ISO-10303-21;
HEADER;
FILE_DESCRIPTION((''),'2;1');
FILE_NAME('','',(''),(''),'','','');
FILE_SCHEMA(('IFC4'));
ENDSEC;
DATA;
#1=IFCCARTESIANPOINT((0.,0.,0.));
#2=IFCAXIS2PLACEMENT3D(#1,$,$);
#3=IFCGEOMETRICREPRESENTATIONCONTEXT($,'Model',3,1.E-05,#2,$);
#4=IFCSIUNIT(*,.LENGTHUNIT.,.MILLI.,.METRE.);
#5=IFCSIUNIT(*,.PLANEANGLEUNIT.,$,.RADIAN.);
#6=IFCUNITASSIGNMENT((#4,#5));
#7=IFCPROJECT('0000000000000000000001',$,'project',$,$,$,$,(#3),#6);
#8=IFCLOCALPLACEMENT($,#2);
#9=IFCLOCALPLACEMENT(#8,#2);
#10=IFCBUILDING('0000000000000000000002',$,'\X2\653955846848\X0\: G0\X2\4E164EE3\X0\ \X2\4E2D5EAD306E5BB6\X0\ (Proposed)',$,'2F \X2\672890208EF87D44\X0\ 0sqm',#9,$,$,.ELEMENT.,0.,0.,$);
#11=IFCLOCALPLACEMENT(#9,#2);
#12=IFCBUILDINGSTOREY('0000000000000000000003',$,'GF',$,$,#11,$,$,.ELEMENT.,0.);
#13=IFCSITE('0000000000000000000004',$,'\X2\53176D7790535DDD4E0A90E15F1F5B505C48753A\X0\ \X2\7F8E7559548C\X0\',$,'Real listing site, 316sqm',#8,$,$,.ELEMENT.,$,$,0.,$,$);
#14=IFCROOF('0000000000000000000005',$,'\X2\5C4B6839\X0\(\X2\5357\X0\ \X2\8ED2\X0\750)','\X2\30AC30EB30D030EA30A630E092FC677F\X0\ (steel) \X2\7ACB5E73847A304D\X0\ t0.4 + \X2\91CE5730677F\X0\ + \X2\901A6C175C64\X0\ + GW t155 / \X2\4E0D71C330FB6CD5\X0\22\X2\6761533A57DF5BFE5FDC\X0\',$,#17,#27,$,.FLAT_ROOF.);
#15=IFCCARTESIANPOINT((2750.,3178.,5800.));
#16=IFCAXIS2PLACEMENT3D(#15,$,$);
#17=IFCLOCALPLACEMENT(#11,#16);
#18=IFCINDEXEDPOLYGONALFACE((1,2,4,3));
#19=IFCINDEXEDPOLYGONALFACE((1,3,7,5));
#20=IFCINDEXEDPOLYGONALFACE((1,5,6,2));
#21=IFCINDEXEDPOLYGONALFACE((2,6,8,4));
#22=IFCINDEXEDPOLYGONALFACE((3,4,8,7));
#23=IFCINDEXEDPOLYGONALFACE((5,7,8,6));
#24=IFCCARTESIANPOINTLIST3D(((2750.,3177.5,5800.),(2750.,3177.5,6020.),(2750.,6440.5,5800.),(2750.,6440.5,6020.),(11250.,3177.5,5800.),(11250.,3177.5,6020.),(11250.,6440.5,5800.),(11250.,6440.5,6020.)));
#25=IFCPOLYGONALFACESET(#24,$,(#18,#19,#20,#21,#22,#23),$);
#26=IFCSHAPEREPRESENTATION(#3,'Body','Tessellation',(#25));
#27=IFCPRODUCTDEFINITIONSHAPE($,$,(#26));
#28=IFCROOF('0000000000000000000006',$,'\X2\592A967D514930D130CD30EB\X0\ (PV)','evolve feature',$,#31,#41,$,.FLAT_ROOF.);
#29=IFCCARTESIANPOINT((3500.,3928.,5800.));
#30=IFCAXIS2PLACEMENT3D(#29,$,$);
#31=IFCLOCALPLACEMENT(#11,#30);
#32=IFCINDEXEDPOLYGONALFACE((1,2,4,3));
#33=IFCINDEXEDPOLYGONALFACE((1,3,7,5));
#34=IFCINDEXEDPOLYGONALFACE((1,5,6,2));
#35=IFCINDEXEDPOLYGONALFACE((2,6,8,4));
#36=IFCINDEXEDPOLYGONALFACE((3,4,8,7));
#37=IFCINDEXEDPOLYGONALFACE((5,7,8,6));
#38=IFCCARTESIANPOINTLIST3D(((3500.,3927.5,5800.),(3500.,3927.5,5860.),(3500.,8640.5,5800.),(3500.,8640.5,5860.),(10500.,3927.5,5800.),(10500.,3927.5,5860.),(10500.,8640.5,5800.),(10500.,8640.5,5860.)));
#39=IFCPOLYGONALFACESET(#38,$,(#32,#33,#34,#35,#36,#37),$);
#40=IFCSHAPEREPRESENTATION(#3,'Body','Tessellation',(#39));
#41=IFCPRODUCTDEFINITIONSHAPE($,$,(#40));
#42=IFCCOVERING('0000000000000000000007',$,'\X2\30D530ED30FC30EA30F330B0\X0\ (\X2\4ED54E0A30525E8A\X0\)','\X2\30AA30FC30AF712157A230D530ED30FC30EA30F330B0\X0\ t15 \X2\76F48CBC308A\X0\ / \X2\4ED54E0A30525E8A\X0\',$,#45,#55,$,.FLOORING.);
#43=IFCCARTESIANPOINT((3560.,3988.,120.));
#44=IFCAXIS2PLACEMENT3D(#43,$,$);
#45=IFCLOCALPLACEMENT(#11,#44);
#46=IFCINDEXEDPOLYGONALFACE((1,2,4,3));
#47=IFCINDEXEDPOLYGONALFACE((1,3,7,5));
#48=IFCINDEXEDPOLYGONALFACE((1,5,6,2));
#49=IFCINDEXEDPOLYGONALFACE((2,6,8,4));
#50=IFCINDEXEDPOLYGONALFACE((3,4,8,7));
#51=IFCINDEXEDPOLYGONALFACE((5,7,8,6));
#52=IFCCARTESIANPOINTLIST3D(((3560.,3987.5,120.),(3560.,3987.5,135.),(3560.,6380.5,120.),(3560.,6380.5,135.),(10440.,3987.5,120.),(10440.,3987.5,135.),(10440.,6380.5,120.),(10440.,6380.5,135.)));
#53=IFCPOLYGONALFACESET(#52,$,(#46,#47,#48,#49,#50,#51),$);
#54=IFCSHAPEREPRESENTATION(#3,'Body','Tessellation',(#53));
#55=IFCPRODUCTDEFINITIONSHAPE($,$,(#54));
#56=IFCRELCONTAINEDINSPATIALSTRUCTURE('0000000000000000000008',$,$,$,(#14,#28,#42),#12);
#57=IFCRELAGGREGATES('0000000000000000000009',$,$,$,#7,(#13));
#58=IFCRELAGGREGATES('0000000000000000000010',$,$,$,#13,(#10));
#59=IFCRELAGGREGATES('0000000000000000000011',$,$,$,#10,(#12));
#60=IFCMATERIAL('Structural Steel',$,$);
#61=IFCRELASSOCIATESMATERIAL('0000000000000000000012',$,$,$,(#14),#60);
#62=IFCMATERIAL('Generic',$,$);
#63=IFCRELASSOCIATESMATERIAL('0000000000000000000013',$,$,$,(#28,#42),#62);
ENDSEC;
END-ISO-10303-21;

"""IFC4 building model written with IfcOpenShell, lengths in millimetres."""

from ifc_helpers import new_model, si_unit, frame, frame_2d, origin, place, context, project, spatial, rectangle, extrude, material, element, save


model = new_model("IFC4")

# Units and contexts
model_context = context("Model", 3, precision=1e-05, world=origin())
ifc_project = project(units=[si_unit("LENGTHUNIT", "METRE", prefix="MILLI"), si_unit("PLANEANGLEUNIT", "RADIAN")], contexts=[model_context])

# Site, building, storey
site_placement = place(None, origin())
site = spatial("IfcSite", under=ifc_project, at=site_placement, Name="北海道川上郡弟子屈町 美留和", ObjectType="Real listing site, 316sqm", CompositionType="ELEMENT", RefElevation=0.0)
building_placement = place(site_placement, origin())
building = spatial("IfcBuilding", under=site, at=building_placement, Name="改善案: G0世代 中庭の家 (Proposed)", ObjectType="2F 木造軸組 0sqm", CompositionType="ELEMENT", ElevationOfRefHeight=0.0, ElevationOfTerrain=0.0)
storey_placement = place(building_placement, origin())
storey = spatial("IfcBuildingStorey", under=building, at=storey_placement, Name="GF", CompositionType="ELEMENT", Elevation=0.0)

# Shared definitions
ifc_material_1 = material(Name="Generic")

# Roofs
ifc_material_2 = material(Name="Structural Steel")
for number, where, name in (
    (1, (2750.0, 3178.0, 5800.0), "屋根(南 軒750)"),
):
    element("IfcRoof", number, at=place(storey_placement, frame(where)), inside=storey, material=ifc_material_2, Name=name, Description="ガルバリウム鋼板 (steel) 立平葺き t0.4 + 野地板 + 通気層 + GW t155 / 不燃・法22条区域対応", PredefinedType="FLAT_ROOF", context=model_context, shape_type="SweptSolid", body=[
        extrude(rectangle(XDim=8500.0, YDim=3263.0, at=frame_2d((4250.0, 1631.0))), frame((2750.0, 3178.0, 5800.0)), (0.0, 0.0, 1.0), 220.0),
    ])
roof_placement = place(storey_placement, frame((3500.0, 3928.0, 5800.0)))
element("IfcRoof", 2, at=roof_placement, inside=storey, material=ifc_material_1, Name="太陽光パネル (PV)", Description="evolve feature", PredefinedType="FLAT_ROOF", context=model_context, shape_type="SweptSolid", body=[
    extrude(rectangle(XDim=7000.0, YDim=4713.0, at=frame_2d((3500.0, 2356.0))), frame((3500.0, 3928.0, 5800.0)), (0.0, 0.0, 1.0), 60.0),
])

# Covering
covering_placement = place(storey_placement, frame((3560.0, 3988.0, 120.0)))
element("IfcCovering", 3, at=covering_placement, inside=storey, material=ifc_material_1, Name="フローリング (仕上げ床)", Description="オーク無垢フローリング t15 直貼り / 仕上げ床", PredefinedType="FLOORING", context=model_context, shape_type="SweptSolid", body=[
    extrude(rectangle(XDim=6880.0, YDim=2393.0, at=frame_2d((3440.0, 1196.0))), frame((3560.0, 3988.0, 120.0)), (0.0, 0.0, 1.0), 15.0),
])

save(model, "model.ifc")
